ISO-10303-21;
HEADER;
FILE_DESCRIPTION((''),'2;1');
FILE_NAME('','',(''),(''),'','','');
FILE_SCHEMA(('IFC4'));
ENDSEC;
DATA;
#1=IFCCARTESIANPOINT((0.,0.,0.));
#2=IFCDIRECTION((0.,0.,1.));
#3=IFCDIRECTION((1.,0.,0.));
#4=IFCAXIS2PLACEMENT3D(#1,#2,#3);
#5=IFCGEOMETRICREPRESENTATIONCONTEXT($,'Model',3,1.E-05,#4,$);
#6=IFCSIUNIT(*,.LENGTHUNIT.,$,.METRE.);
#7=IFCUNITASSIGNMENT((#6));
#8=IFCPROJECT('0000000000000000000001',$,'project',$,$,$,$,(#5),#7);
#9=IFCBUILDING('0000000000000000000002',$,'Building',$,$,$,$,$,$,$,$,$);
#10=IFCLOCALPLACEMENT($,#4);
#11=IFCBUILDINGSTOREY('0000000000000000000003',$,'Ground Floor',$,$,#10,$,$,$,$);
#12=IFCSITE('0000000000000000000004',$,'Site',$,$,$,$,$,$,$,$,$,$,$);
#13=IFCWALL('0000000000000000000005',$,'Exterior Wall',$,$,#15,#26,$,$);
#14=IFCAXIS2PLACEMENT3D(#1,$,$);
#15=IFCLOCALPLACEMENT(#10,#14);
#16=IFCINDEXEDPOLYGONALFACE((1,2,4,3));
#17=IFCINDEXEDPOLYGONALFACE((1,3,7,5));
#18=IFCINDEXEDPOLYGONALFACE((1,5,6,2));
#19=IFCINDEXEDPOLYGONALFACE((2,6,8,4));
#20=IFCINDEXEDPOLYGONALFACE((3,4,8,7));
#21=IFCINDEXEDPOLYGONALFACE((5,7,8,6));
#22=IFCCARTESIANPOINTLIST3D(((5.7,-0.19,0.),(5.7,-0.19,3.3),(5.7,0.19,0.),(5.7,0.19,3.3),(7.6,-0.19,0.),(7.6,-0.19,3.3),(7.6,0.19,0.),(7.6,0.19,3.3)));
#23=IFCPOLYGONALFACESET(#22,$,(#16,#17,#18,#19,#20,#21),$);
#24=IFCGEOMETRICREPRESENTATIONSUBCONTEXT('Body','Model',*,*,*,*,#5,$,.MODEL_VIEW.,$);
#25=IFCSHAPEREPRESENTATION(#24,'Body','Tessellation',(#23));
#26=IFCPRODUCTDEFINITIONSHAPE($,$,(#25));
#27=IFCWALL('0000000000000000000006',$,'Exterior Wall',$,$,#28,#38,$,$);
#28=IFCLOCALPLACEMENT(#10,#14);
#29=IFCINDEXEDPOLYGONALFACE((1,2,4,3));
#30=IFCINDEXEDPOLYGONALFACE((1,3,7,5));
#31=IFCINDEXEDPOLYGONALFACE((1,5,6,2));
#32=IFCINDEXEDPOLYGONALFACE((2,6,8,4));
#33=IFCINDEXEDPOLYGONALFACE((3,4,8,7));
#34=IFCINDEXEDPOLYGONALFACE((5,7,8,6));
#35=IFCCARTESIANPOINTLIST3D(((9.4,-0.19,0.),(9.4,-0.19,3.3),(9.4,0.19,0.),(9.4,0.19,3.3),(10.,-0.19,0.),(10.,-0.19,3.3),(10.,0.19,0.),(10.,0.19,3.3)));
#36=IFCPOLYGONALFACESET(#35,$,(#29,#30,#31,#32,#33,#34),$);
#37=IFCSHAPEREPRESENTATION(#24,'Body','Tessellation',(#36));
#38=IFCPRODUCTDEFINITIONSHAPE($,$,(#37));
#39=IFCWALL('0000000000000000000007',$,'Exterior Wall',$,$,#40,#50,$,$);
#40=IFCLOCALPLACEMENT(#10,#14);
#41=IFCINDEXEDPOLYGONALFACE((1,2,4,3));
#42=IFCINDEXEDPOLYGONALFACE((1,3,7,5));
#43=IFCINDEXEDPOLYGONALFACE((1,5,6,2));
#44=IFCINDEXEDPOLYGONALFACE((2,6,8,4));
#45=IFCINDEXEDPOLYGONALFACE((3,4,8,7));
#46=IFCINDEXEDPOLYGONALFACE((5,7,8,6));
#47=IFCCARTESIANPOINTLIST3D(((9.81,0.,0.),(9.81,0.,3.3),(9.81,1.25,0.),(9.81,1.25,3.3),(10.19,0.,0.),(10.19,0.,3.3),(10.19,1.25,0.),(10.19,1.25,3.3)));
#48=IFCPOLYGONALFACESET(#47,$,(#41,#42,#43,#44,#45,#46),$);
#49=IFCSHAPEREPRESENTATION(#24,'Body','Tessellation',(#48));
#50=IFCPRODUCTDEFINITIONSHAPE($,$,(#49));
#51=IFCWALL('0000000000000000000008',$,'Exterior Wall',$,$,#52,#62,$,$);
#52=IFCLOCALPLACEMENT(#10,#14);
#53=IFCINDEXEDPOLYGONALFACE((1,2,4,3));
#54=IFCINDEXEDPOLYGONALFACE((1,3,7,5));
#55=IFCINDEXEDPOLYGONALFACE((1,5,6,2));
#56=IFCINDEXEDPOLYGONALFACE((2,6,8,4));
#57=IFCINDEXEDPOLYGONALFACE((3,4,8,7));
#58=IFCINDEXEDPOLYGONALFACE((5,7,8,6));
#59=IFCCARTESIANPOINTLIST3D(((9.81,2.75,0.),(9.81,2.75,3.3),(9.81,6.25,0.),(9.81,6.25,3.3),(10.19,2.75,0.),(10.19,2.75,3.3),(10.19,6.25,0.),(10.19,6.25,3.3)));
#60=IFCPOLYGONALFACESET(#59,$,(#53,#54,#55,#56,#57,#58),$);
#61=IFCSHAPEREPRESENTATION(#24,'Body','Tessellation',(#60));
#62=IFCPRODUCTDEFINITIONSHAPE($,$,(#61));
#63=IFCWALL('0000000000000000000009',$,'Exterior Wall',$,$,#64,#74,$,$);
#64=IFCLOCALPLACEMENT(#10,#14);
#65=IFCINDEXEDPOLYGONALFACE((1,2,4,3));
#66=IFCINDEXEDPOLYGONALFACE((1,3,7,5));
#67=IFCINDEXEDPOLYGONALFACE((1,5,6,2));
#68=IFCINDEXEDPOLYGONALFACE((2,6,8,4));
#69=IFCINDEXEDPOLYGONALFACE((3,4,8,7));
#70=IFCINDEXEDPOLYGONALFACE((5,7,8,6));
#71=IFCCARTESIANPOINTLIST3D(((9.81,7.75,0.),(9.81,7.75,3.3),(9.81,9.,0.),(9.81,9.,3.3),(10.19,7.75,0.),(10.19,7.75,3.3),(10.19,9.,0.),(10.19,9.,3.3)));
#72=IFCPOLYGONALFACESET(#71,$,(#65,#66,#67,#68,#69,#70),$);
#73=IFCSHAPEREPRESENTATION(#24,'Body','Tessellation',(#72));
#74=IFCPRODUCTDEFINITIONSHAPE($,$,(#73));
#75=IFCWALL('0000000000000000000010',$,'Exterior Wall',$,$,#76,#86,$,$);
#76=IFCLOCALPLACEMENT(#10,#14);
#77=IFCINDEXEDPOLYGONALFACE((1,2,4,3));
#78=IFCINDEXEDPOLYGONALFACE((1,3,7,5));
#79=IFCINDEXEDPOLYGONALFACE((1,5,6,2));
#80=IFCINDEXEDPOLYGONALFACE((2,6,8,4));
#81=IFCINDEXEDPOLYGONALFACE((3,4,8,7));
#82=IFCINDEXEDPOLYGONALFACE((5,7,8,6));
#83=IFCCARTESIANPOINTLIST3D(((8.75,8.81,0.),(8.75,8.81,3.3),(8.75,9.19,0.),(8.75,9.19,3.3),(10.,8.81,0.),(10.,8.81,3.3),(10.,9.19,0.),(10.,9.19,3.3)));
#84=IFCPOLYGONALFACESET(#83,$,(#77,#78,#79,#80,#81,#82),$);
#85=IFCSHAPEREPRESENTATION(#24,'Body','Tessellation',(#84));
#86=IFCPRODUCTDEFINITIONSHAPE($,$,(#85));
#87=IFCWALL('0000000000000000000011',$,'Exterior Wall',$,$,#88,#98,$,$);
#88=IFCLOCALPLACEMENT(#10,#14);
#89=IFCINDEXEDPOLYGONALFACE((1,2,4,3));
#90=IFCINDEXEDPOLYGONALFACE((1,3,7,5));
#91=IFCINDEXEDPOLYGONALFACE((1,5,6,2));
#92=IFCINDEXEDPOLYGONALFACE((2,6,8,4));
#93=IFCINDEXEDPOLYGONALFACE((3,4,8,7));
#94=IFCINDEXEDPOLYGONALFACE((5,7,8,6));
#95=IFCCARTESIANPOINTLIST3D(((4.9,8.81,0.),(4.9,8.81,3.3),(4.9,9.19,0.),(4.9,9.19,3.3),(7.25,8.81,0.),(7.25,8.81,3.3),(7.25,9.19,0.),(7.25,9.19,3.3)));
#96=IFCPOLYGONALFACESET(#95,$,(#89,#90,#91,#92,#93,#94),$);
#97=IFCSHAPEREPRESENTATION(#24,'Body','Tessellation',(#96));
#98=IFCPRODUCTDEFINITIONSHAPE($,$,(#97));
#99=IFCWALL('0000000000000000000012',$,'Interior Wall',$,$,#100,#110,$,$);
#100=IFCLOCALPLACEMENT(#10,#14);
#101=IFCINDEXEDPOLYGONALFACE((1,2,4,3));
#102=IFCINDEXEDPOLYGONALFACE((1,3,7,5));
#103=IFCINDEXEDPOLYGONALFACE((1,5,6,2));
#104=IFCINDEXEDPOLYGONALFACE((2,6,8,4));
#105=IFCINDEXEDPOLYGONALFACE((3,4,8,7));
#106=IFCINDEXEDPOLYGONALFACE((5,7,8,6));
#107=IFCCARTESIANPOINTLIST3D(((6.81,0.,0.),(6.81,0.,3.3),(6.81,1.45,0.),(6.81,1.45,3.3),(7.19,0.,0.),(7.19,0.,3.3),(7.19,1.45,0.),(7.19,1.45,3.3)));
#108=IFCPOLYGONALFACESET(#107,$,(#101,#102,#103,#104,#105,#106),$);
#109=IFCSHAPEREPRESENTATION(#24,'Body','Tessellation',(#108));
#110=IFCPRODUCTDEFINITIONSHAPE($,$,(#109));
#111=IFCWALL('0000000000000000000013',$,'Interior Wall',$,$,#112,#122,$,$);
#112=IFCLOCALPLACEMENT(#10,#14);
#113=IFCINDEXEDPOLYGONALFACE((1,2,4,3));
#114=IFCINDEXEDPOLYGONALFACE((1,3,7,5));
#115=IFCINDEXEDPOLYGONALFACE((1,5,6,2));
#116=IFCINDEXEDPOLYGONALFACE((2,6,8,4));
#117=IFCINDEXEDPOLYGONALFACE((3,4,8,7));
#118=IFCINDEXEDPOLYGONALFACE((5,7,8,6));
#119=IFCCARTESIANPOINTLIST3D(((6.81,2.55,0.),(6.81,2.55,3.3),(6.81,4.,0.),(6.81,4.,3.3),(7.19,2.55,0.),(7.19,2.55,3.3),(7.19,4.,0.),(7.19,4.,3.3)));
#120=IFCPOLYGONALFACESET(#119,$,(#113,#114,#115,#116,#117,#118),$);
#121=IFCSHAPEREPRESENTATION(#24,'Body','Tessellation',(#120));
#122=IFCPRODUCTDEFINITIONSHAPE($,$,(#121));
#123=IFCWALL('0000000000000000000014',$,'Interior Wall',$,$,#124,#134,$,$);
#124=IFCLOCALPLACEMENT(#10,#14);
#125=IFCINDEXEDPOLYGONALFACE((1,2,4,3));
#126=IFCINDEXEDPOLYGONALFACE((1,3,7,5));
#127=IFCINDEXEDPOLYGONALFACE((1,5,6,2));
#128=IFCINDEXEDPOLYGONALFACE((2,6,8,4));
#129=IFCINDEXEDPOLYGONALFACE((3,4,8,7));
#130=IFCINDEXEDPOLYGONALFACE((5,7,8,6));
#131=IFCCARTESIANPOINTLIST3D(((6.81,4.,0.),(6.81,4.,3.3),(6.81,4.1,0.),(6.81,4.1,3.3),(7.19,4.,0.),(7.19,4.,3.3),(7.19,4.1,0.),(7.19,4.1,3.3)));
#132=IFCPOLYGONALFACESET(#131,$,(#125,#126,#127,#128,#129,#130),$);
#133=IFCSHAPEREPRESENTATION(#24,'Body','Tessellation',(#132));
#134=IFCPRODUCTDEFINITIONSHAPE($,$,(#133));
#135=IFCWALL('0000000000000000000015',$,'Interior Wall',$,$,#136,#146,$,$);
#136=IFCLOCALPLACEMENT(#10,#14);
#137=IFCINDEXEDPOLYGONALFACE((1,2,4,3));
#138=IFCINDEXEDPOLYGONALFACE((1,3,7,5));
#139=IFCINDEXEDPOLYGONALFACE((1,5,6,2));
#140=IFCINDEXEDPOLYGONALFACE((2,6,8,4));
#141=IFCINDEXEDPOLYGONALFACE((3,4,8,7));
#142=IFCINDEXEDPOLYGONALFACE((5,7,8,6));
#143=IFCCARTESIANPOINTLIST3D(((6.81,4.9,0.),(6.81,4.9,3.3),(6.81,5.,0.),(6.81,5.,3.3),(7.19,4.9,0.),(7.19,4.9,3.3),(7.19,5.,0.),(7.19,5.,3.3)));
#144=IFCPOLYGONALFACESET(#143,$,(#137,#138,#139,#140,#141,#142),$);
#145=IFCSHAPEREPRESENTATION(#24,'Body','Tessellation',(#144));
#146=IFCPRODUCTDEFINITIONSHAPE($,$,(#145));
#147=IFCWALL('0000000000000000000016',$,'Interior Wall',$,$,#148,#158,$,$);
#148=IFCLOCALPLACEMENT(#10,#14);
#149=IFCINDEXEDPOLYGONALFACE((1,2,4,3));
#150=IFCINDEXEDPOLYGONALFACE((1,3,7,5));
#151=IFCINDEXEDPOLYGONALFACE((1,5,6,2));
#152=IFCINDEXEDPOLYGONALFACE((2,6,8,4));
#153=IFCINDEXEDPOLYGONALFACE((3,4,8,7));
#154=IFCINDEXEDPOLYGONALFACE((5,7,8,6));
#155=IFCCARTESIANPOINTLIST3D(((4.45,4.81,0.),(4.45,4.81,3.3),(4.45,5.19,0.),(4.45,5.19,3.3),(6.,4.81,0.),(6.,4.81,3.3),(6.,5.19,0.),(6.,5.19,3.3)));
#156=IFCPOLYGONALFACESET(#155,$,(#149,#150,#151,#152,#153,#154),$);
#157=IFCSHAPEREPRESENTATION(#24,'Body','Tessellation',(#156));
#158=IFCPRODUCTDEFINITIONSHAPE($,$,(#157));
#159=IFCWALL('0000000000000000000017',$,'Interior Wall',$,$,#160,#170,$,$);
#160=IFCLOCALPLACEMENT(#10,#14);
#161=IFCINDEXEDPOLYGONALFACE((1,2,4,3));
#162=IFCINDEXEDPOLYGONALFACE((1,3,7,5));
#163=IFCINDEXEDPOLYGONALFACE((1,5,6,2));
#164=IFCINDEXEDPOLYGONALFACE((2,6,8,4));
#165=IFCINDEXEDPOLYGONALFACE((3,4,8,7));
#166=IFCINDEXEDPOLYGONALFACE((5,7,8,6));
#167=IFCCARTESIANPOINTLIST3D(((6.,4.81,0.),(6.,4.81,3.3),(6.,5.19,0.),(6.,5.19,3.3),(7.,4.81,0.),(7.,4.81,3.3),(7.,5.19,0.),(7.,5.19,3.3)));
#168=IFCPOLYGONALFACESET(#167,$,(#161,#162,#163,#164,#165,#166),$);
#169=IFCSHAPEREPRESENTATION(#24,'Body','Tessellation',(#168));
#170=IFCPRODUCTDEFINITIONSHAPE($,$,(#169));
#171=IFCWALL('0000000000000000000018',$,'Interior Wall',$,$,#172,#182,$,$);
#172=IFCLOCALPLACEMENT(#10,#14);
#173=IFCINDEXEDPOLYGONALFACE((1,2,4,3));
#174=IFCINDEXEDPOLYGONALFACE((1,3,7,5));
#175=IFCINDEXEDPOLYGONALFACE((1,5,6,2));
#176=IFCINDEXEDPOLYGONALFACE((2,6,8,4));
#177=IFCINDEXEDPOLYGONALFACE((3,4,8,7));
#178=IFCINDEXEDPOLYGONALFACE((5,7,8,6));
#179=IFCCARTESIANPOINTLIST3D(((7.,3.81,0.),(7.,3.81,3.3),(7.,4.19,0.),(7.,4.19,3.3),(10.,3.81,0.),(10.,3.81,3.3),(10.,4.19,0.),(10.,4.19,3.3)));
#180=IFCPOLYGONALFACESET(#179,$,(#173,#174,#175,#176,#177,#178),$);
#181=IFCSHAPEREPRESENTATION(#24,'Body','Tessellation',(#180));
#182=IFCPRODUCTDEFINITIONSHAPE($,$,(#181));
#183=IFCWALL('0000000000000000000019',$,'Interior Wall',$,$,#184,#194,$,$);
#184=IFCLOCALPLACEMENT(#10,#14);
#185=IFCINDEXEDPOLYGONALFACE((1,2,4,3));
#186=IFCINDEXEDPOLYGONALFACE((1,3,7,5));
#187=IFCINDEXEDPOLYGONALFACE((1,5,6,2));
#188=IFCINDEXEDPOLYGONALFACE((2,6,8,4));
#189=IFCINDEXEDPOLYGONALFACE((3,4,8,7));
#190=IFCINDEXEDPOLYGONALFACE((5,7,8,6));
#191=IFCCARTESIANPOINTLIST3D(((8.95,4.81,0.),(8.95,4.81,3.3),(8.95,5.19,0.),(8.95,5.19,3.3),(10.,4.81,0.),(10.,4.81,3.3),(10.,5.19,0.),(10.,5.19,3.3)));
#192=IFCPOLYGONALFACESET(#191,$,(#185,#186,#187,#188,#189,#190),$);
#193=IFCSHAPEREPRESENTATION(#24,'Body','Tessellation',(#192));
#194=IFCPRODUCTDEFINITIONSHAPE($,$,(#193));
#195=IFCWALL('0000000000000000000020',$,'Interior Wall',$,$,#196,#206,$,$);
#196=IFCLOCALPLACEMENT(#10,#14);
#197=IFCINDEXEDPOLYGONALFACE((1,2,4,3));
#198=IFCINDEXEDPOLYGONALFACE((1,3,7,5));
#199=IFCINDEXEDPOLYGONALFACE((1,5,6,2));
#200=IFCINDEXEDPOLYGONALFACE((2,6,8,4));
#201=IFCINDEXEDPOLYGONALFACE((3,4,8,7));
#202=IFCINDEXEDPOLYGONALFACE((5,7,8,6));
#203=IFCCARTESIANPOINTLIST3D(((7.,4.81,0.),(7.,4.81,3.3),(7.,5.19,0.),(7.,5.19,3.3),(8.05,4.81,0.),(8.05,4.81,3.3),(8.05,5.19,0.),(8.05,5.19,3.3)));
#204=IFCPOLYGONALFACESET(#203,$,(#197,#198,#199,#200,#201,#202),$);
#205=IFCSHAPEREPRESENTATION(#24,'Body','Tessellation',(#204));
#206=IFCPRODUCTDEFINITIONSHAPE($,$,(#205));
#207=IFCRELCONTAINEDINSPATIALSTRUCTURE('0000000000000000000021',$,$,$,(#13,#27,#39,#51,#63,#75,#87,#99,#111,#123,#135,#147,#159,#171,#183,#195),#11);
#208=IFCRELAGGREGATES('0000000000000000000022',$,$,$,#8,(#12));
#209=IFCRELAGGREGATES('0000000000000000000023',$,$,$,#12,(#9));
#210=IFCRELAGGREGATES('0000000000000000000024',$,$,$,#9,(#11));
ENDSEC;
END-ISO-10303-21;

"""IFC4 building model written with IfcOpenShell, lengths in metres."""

from ifc_helpers import new_model, si_unit, frame, origin_with_axes, place, context, subcontext, project, spatial, indexed_curve, outline, extrude, element, save


model = new_model("IFC4")

# Units and contexts
model_context = context("Model", 3, precision=1e-05, world=origin_with_axes())
body_context = subcontext(model_context, "Body", "Model", "MODEL_VIEW")
ifc_project = project(units=[si_unit("LENGTHUNIT", "METRE")], contexts=[model_context])

# Site, building, storey
site = spatial("IfcSite", under=ifc_project, Name="Site")
building = spatial("IfcBuilding", under=site, Name="Building")
storey_placement = place(None, origin_with_axes())
storey = spatial("IfcBuildingStorey", under=building, at=storey_placement, Name="Ground Floor")

# Walls
wall_1_placement = place(storey_placement, frame((5.7, 0.0, 0.0), z_axis=(0.0, 0.0, 1.0), x_axis=(1.0, 0.0, 0.0)))
element("IfcWall", 1, at=wall_1_placement, inside=storey, Name="Exterior Wall", context=body_context, shape_type="SweptSolid", body=[
    extrude(outline(indexed_curve([(0.0, 0.0), (0.0, 0.38), (1.9, 0.38), (1.9, 0.0), (0.0, 0.0)], self_intersect=False)), frame((0.0, -0.19, 0.0), z_axis=(0.0, 0.0, 1.0), x_axis=(1.0, 0.0, 0.0)), (0.0, 0.0, 1.0), 3.3),
])
wall_2_placement = place(storey_placement, frame((9.4, 0.0, 0.0), z_axis=(0.0, 0.0, 1.0), x_axis=(1.0, 0.0, 0.0)))
element("IfcWall", 2, at=wall_2_placement, inside=storey, Name="Exterior Wall", context=body_context, shape_type="SweptSolid", body=[
    extrude(outline(indexed_curve([(0.0, 0.0), (0.0, 0.38), (0.6, 0.38), (0.6, 0.0), (0.0, 0.0)], self_intersect=False)), frame((0.0, -0.19, 0.0), z_axis=(0.0, 0.0, 1.0), x_axis=(1.0, 0.0, 0.0)), (0.0, 0.0, 1.0), 3.3),
])
wall_3_placement = place(storey_placement, frame((10.0, 0.0, 0.0), z_axis=(0.0, 0.0, 1.0), x_axis=(0.0, 1.0, 0.0)))
element("IfcWall", 3, at=wall_3_placement, inside=storey, Name="Exterior Wall", context=body_context, shape_type="SweptSolid", body=[
    extrude(outline(indexed_curve([(0.0, 0.0), (0.0, 0.38), (1.25, 0.38), (1.25, 0.0), (0.0, 0.0)], self_intersect=False)), frame((0.0, -0.19, 0.0), z_axis=(0.0, 0.0, 1.0), x_axis=(1.0, 0.0, 0.0)), (0.0, 0.0, 1.0), 3.3),
])
wall_4_placement = place(storey_placement, frame((10.0, 2.75, 0.0), z_axis=(0.0, 0.0, 1.0), x_axis=(0.0, 1.0, 0.0)))
element("IfcWall", 4, at=wall_4_placement, inside=storey, Name="Exterior Wall", context=body_context, shape_type="SweptSolid", body=[
    extrude(outline(indexed_curve([(0.0, 0.0), (0.0, 0.38), (3.5, 0.38), (3.5, 0.0), (0.0, 0.0)], self_intersect=False)), frame((0.0, -0.19, 0.0), z_axis=(0.0, 0.0, 1.0), x_axis=(1.0, 0.0, 0.0)), (0.0, 0.0, 1.0), 3.3),
])
for number, where, z_axis, x_axis, name in (
    (5, (10.0, 7.75, 0.0), (0.0, 0.0, 1.0), (0.0, 1.0, 0.0), "Exterior Wall"),
    (6, (10.0, 9.0, 0.0), (0.0, 0.0, 1.0), (-1.0, 0.0, 0.0), "Exterior Wall"),
):
    element("IfcWall", number, at=place(storey_placement, frame(where, z_axis=z_axis, x_axis=x_axis)), inside=storey, Name=name, context=body_context, shape_type="SweptSolid", body=[
        extrude(outline(indexed_curve([(0.0, 0.0), (0.0, 0.38), (1.25, 0.38), (1.25, 0.0), (0.0, 0.0)], self_intersect=False)), frame((0.0, -0.19, 0.0), z_axis=(0.0, 0.0, 1.0), x_axis=(1.0, 0.0, 0.0)), (0.0, 0.0, 1.0), 3.3),
    ])
wall_5_placement = place(storey_placement, frame((7.25, 9.0, 0.0), z_axis=(0.0, 0.0, 1.0), x_axis=(-1.0, 0.0, 0.0)))
element("IfcWall", 7, at=wall_5_placement, inside=storey, Name="Exterior Wall", context=body_context, shape_type="SweptSolid", body=[
    extrude(outline(indexed_curve([(0.0, 0.0), (0.0, 0.38), (2.35, 0.38), (2.35, 0.0), (0.0, 0.0)], self_intersect=False)), frame((0.0, -0.19, 0.0), z_axis=(0.0, 0.0, 1.0), x_axis=(1.0, 0.0, 0.0)), (0.0, 0.0, 1.0), 3.3),
])
wall_6_placement = place(storey_placement, frame((7.0, 0.0, 0.0), z_axis=(0.0, 0.0, 1.0), x_axis=(0.0, 1.0, 0.0)))
element("IfcWall", 8, at=wall_6_placement, inside=storey, Name="Interior Wall", context=body_context, shape_type="SweptSolid", body=[
    extrude(outline(indexed_curve([(0.0, 0.0), (0.0, 0.38), (1.45, 0.38), (1.45, 0.0), (0.0, 0.0)], self_intersect=False)), frame((0.0, -0.19, 0.0), z_axis=(0.0, 0.0, 1.0), x_axis=(1.0, 0.0, 0.0)), (0.0, 0.0, 1.0), 3.3),
])
wall_7_placement = place(storey_placement, frame((7.0, 2.55, 0.0), z_axis=(0.0, 0.0, 1.0), x_axis=(0.0, 1.0, 0.0)))
element("IfcWall", 9, at=wall_7_placement, inside=storey, Name="Interior Wall", context=body_context, shape_type="SweptSolid", body=[
    extrude(outline(indexed_curve([(0.0, 0.0), (0.0, 0.38), (1.45, 0.38), (1.45, 0.0), (0.0, 0.0)], self_intersect=False)), frame((0.0, -0.19, 0.0), z_axis=(0.0, 0.0, 1.0), x_axis=(1.0, 0.0, 0.0)), (0.0, 0.0, 1.0), 3.3),
])
for number, where, z_axis, x_axis, name in (
    (10, (7.0, 4.0, 0.0), (0.0, 0.0, 1.0), (0.0, 1.0, 0.0), "Interior Wall"),
    (11, (7.0, 4.9, 0.0), (0.0, 0.0, 1.0), (0.0, 1.0, 0.0), "Interior Wall"),
):
    element("IfcWall", number, at=place(storey_placement, frame(where, z_axis=z_axis, x_axis=x_axis)), inside=storey, Name=name, context=body_context, shape_type="SweptSolid", body=[
        extrude(outline(indexed_curve([(0.0, 0.0), (0.0, 0.38), (0.1, 0.38), (0.1, 0.0), (0.0, 0.0)], self_intersect=False)), frame((0.0, -0.19, 0.0), z_axis=(0.0, 0.0, 1.0), x_axis=(1.0, 0.0, 0.0)), (0.0, 0.0, 1.0), 3.3),
    ])
wall_8_placement = place(storey_placement, frame((6.0, 5.0, 0.0), z_axis=(0.0, 0.0, 1.0), x_axis=(-1.0, 0.0, 0.0)))
element("IfcWall", 12, at=wall_8_placement, inside=storey, Name="Interior Wall", context=body_context, shape_type="SweptSolid", body=[
    extrude(outline(indexed_curve([(0.0, 0.0), (0.0, 0.38), (1.55, 0.38), (1.55, 0.0), (0.0, 0.0)], self_intersect=False)), frame((0.0, -0.19, 0.0), z_axis=(0.0, 0.0, 1.0), x_axis=(1.0, 0.0, 0.0)), (0.0, 0.0, 1.0), 3.3),
])
wall_9_placement = place(storey_placement, frame((7.0, 5.0, 0.0), z_axis=(0.0, 0.0, 1.0), x_axis=(-1.0, 0.0, 0.0)))
element("IfcWall", 13, at=wall_9_placement, inside=storey, Name="Interior Wall", context=body_context, shape_type="SweptSolid", body=[
    extrude(outline(indexed_curve([(0.0, 0.0), (0.0, 0.38), (1.0, 0.38), (1.0, 0.0), (0.0, 0.0)], self_intersect=False)), frame((0.0, -0.19, 0.0), z_axis=(0.0, 0.0, 1.0), x_axis=(1.0, 0.0, 0.0)), (0.0, 0.0, 1.0), 3.3),
])
wall_10_placement = place(storey_placement, frame((10.0, 4.0, 0.0), z_axis=(0.0, 0.0, 1.0), x_axis=(-1.0, 0.0, 0.0)))
element("IfcWall", 14, at=wall_10_placement, inside=storey, Name="Interior Wall", context=body_context, shape_type="SweptSolid", body=[
    extrude(outline(indexed_curve([(0.0, 0.0), (0.0, 0.38), (3.0, 0.38), (3.0, 0.0), (0.0, 0.0)], self_intersect=False)), frame((0.0, -0.19, 0.0), z_axis=(0.0, 0.0, 1.0), x_axis=(1.0, 0.0, 0.0)), (0.0, 0.0, 1.0), 3.3),
])
for number, where, z_axis, x_axis, name in (
    (15, (10.0, 5.0, 0.0), (0.0, 0.0, 1.0), (-1.0, 0.0, 0.0), "Interior Wall"),
    (16, (8.05, 5.0, 0.0), (0.0, 0.0, 1.0), (-1.0, 0.0, 0.0), "Interior Wall"),
):
    element("IfcWall", number, at=place(storey_placement, frame(where, z_axis=z_axis, x_axis=x_axis)), inside=storey, Name=name, context=body_context, shape_type="SweptSolid", body=[
        extrude(outline(indexed_curve([(0.0, 0.0), (0.0, 0.38), (1.05, 0.38), (1.05, 0.0), (0.0, 0.0)], self_intersect=False)), frame((0.0, -0.19, 0.0), z_axis=(0.0, 0.0, 1.0), x_axis=(1.0, 0.0, 0.0)), (0.0, 0.0, 1.0), 3.3),
    ])

save(model, "model.ifc")
